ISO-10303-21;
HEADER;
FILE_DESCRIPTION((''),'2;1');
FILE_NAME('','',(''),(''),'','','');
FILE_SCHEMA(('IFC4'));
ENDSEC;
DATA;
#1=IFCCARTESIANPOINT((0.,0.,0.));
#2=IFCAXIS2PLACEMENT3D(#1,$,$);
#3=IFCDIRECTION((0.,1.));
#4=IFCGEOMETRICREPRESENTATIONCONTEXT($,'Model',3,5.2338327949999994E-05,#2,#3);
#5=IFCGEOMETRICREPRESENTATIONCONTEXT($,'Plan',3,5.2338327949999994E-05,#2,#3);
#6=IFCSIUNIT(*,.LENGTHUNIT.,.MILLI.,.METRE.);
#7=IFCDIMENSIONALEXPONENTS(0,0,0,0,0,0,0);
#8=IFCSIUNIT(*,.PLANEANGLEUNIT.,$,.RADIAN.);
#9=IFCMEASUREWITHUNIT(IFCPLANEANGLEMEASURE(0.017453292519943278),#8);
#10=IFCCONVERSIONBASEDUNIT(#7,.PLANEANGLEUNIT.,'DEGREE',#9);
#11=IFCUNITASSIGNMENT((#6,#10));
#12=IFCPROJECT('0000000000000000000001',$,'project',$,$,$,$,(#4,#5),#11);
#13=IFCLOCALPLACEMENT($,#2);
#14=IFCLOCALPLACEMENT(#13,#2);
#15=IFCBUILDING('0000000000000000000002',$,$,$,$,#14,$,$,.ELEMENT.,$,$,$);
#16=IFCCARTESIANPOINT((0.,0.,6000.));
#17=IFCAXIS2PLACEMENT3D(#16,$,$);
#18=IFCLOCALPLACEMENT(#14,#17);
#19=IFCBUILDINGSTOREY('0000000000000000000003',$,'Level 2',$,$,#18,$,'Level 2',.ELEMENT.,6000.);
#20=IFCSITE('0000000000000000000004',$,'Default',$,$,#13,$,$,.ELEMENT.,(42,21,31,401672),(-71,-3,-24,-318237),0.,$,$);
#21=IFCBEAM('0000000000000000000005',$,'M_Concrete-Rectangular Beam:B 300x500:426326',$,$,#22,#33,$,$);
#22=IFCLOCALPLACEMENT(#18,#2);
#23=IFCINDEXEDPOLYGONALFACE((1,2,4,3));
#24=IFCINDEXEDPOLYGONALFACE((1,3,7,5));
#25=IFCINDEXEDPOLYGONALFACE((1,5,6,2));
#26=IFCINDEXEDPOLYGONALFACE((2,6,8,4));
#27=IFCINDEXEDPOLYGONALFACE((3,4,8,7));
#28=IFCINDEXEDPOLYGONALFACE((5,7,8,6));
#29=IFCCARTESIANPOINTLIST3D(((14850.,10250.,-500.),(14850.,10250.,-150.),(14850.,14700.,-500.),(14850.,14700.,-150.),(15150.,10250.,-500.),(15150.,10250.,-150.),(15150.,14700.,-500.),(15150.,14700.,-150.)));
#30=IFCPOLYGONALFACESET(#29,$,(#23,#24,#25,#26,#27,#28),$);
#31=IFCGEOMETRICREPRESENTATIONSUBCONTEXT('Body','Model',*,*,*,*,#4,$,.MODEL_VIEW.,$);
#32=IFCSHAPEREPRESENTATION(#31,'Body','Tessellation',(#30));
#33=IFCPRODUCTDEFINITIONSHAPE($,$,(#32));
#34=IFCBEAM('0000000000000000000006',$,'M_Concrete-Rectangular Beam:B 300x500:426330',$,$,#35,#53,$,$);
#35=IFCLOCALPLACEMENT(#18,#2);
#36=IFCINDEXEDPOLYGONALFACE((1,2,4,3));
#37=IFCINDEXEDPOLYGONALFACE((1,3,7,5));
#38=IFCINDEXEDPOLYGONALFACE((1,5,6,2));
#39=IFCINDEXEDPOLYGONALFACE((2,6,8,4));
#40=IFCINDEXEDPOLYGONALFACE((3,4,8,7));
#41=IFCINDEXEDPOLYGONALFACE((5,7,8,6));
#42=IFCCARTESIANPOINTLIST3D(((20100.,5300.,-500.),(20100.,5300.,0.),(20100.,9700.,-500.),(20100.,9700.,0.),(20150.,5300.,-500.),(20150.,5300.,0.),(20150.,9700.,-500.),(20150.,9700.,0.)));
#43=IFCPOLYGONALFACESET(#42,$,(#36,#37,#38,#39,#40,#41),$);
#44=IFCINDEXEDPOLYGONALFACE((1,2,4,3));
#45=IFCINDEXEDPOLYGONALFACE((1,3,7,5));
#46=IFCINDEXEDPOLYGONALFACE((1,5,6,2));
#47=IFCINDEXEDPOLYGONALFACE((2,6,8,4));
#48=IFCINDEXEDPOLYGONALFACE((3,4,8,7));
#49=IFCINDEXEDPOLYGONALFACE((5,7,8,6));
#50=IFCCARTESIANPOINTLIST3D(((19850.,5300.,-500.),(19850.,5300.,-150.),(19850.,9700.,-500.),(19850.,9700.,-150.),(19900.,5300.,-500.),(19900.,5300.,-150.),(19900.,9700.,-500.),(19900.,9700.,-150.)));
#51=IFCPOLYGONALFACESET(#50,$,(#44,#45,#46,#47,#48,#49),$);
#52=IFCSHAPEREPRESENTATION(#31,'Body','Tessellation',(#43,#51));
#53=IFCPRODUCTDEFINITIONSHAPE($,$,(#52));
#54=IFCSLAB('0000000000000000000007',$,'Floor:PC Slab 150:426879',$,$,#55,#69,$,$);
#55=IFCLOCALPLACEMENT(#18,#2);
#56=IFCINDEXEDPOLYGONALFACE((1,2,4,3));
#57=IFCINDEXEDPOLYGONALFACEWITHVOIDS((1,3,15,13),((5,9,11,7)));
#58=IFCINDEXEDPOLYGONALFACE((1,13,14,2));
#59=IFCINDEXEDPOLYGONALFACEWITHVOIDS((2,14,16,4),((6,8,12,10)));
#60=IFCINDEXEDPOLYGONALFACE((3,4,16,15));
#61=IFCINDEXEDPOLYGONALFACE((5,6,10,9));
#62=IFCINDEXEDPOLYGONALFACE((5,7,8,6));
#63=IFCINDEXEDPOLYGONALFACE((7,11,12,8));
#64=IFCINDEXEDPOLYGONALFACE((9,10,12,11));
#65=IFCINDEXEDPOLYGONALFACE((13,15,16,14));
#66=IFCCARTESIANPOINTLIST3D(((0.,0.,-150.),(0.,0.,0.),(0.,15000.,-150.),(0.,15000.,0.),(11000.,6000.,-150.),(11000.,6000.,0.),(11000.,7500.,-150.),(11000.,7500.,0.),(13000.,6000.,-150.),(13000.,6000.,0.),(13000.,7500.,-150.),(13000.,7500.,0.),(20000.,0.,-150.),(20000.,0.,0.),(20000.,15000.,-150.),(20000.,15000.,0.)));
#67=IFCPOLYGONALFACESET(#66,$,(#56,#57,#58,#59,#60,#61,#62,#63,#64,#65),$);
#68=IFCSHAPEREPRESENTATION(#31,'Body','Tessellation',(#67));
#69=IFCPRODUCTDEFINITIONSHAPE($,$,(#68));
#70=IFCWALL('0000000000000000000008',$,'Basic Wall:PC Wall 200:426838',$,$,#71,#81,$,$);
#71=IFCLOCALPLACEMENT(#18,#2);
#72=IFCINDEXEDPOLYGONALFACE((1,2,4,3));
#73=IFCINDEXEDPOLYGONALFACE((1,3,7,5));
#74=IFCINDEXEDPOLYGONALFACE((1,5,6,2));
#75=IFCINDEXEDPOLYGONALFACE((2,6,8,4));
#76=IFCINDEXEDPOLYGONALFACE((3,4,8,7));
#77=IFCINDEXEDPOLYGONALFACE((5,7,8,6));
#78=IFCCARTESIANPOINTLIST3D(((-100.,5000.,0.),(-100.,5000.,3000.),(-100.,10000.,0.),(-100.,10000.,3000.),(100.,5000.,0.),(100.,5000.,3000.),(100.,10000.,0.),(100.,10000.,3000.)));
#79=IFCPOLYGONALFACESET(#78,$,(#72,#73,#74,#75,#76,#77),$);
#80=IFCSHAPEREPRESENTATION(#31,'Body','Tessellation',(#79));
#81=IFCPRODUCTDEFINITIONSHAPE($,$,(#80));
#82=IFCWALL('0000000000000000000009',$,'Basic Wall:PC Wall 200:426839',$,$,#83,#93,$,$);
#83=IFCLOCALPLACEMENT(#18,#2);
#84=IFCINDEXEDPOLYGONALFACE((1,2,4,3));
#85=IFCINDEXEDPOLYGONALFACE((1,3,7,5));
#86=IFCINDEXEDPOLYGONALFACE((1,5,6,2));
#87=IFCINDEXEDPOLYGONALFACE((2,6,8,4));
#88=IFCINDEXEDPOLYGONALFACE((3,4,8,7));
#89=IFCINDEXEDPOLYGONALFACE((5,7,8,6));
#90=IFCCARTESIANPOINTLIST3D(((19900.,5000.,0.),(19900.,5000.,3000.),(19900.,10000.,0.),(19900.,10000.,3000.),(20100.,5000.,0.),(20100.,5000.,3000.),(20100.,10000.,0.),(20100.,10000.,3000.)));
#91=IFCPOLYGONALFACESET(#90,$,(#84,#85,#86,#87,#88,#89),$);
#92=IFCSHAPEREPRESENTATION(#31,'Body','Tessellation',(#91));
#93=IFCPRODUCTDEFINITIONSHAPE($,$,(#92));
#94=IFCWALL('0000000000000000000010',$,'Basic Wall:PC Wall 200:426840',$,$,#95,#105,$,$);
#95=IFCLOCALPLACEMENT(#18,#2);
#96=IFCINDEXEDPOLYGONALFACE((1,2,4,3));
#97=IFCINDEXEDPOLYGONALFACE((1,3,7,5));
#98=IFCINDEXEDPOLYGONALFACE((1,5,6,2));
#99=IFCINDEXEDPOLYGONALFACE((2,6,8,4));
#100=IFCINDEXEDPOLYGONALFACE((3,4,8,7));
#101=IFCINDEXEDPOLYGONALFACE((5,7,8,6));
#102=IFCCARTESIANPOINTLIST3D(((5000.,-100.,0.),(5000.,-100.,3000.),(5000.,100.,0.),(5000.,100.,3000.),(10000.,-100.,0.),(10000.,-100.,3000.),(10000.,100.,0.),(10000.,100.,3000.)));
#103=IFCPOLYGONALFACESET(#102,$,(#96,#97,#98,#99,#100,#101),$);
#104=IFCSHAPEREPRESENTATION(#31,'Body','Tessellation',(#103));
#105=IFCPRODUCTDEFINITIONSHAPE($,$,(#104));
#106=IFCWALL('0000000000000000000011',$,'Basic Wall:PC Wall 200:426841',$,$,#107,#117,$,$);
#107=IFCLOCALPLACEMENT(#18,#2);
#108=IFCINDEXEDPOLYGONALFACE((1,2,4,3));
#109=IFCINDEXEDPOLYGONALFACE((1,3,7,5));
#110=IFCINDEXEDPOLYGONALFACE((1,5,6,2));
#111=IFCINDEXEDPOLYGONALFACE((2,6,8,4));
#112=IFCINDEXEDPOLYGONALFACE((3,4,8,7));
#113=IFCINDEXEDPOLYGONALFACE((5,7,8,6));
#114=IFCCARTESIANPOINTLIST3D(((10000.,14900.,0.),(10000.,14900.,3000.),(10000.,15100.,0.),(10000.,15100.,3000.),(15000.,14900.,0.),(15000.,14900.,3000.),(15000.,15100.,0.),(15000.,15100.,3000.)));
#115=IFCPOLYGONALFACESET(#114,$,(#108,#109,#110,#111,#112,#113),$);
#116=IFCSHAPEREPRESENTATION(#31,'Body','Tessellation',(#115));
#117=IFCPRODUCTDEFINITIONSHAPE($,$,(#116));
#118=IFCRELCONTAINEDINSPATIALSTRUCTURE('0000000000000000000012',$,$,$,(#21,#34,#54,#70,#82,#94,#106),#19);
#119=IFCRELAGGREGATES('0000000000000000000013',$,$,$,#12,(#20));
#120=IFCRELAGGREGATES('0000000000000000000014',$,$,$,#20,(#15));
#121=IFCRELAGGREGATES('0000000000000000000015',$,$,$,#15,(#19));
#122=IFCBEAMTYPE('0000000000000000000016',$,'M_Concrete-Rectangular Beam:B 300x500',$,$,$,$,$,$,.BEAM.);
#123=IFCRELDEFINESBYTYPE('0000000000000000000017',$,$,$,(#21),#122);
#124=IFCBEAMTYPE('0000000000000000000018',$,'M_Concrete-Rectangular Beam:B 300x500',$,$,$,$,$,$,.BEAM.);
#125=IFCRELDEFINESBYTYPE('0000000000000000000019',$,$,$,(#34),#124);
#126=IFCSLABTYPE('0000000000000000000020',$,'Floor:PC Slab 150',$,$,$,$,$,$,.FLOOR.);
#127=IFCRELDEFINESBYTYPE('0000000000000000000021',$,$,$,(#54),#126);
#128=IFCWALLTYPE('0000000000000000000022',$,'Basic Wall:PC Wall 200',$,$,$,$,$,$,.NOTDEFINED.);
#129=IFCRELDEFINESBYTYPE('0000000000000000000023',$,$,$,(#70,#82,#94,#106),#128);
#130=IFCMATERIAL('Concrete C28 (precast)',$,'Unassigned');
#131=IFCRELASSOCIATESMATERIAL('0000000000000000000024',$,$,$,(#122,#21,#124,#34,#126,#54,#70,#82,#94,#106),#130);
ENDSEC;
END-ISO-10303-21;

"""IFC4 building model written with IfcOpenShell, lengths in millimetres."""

from ifc_helpers import new_model, entity, si_unit, converted_unit, direction, frame, origin, place, context, subcontext, project, spatial, indexed_curve, outline, extrude, source, transform, mapped, material, type_object, type_shapes, element, save


model = new_model("IFC4")

# Units and contexts
model_context = context("Model", 3, precision=5.2338327949999994e-05, world=origin(), true_north=direction((0.0, 1.0)))
plan_context = context("Plan", 3, precision=5.2338327949999994e-05, world=origin(), true_north=direction((0.0, 1.0)))
body_context = subcontext(model_context, "Body", "Model", "MODEL_VIEW")
ifc_project = project(units=[si_unit("LENGTHUNIT", "METRE", prefix="MILLI"), converted_unit("PLANEANGLEUNIT", "DEGREE", entity("IfcPlaneAngleMeasure", 0.017453292519943278), si_unit("PLANEANGLEUNIT", "RADIAN"), dimensions=[0, 0, 0, 0, 0, 0, 0])], contexts=[model_context, plan_context])

# Site, building, storey
site_placement = place(None, origin())
site = spatial("IfcSite", under=ifc_project, at=site_placement, Name="Default", CompositionType="ELEMENT", RefLatitude=(42, 21, 31, 401672), RefLongitude=(-71, -3, -24, -318237), RefElevation=0.0)
building_placement = place(site_placement, origin())
building = spatial("IfcBuilding", under=site, at=building_placement, CompositionType="ELEMENT")
storey_placement = place(building_placement, frame((0.0, 0.0, 6000.0)))
storey = spatial("IfcBuildingStorey", under=building, at=storey_placement, Name="Level 2", LongName="Level 2", CompositionType="ELEMENT", Elevation=6000.0)

# Beams
ifc_material = material(Name="Concrete C28 (precast)", Category="Unassigned")
beam_type_1 = type_object("IfcBeamType", Name="M_Concrete-Rectangular Beam:B 300x500", PredefinedType="BEAM", material=ifc_material)
shared_shape_1 = source(origin(), body_context, "Body", "SweptSolid", [
    extrude(outline(indexed_curve([(-150.0, -175.0), (150.0, -175.0), (150.0, 175.0), (-150.0, 175.0), (-150.0, -175.0)], self_intersect=False)), frame((15000.0, 10250.0, 5675.0), z_axis=(0.0, 1.0, 0.0), x_axis=(-1.0, 0.0, 0.0)), (0.0, 0.0, 1.0), 4450.0),
])
type_shapes(beam_type_1, [shared_shape_1])
beam_1_placement = place(storey_placement, frame((0.0, 0.0, -6000.0)))
element("IfcBeam", 1, at=beam_1_placement, inside=storey, type_object=beam_type_1, material=ifc_material, Name="M_Concrete-Rectangular Beam:B 300x500:426326", context=body_context, shape_type="MappedRepresentation", body=[
    mapped(shared_shape_1, transform((0.0, 0.0, 0.0), scale=1.0)),
])
beam_type_2 = type_object("IfcBeamType", Name="M_Concrete-Rectangular Beam:B 300x500", PredefinedType="BEAM", material=ifc_material)
shared_shape_2 = source(origin(), body_context, "Body", "SweptSolid", [
    extrude(outline(indexed_curve([(-25.0, -250.0), (25.0, -250.0), (25.0, 250.0), (-25.0, 250.0), (-25.0, -250.0)], self_intersect=False)), frame((20125.0, 5300.0, 5750.0), z_axis=(0.0, 1.0, 0.0), x_axis=(-1.0, 0.0, 0.0)), (0.0, 0.0, 1.0), 4400.0),
    extrude(outline(indexed_curve([(-25.0, -175.0), (25.0, -175.0), (25.0, 175.0), (-25.0, 175.0), (-25.0, -175.0)], self_intersect=False)), frame((19875.0, 5300.0, 5675.0), z_axis=(0.0, 1.0, 0.0), x_axis=(-1.0, 0.0, 0.0)), (0.0, 0.0, 1.0), 4400.0),
])
type_shapes(beam_type_2, [shared_shape_2])
beam_2_placement = place(storey_placement, frame((0.0, 0.0, -6000.0)))
element("IfcBeam", 2, at=beam_2_placement, inside=storey, type_object=beam_type_2, material=ifc_material, Name="M_Concrete-Rectangular Beam:B 300x500:426330", context=body_context, shape_type="MappedRepresentation", body=[
    mapped(shared_shape_2, transform((0.0, 0.0, 0.0), scale=1.0)),
])

# Slab, opening
slab_type = type_object("IfcSlabType", Name="Floor:PC Slab 150", PredefinedType="FLOOR", material=ifc_material)
slab_placement = place(storey_placement, origin())
slab = element("IfcSlab", 3, at=slab_placement, inside=storey, type_object=slab_type, material=ifc_material, Name="Floor:PC Slab 150:426879", context=body_context, shape_type="SweptSolid", body=[
    extrude(outline(indexed_curve([(-7500.0, -10000.0), (7500.0, -10000.0), (7500.0, 10000.0), (-7500.0, 10000.0), (-7500.0, -10000.0)], self_intersect=False), holes=[indexed_curve([(-1500.0, -3000.0), (-1500.0, -1000.0), (0.0, -1000.0), (0.0, -3000.0), (-1500.0, -3000.0)], self_intersect=False)]), frame((10000.0, 7500.0, -150.0), z_axis=(0.0, 0.0, 1.0), x_axis=(0.0, 1.0, 0.0)), (0.0, 0.0, 1.0), 150.0),
])
opening_placement = place(slab_placement, origin())
element("IfcOpeningElement", 4, at=opening_placement, cuts=slab, PredefinedType="OPENING", context=body_context, shape_type="SweptSolid", body=[
    extrude(outline(indexed_curve([(13000.0, 6000.0), (13000.0, 7500.0), (11000.0, 7500.0), (11000.0, 6000.0), (13000.0, 6000.0)], self_intersect=False)), frame((0.0, 0.0, -6000.0)), (0.0, 0.0, 1.0), 20000.0),
])

# Walls
wall_type = type_object("IfcWallType", Name="Basic Wall:PC Wall 200", PredefinedType="NOTDEFINED")
wall_1_placement = place(storey_placement, frame((0.0, 5000.0, 0.0), z_axis=(0.0, 0.0, 1.0), x_axis=(0.0, 1.0, 0.0)))
element("IfcWall", 5, at=wall_1_placement, inside=storey, type_object=wall_type, material=ifc_material, Name="Basic Wall:PC Wall 200:426838", context=body_context, shape_type="SweptSolid", body=[
    extrude(outline(indexed_curve([(5000.0, 100.0), (0.0, 100.0), (0.0, -100.0), (5000.0, -100.0), (5000.0, 100.0)], self_intersect=False)), origin(), (0.0, 0.0, 1.0), 3000.0),
])
wall_2_placement = place(storey_placement, frame((20000.0, 5000.0, 0.0), z_axis=(0.0, 0.0, 1.0), x_axis=(0.0, 1.0, 0.0)))
element("IfcWall", 6, at=wall_2_placement, inside=storey, type_object=wall_type, material=ifc_material, Name="Basic Wall:PC Wall 200:426839", context=body_context, shape_type="SweptSolid", body=[
    extrude(outline(indexed_curve([(5000.0, 100.0), (0.0, 100.0), (0.0, -100.0), (5000.0, -100.0), (5000.0, 100.0)], self_intersect=False)), origin(), (0.0, 0.0, 1.0), 3000.0),
])
wall_3_placement = place(storey_placement, frame((5000.0, 0.0, 0.0)))
element("IfcWall", 7, at=wall_3_placement, inside=storey, type_object=wall_type, material=ifc_material, Name="Basic Wall:PC Wall 200:426840", context=body_context, shape_type="SweptSolid", body=[
    extrude(outline(indexed_curve([(5000.0, 100.0), (0.0, 100.0), (0.0, -100.0), (5000.0, -100.0), (5000.0, 100.0)], self_intersect=False)), origin(), (0.0, 0.0, 1.0), 3000.0),
])
wall_4_placement = place(storey_placement, frame((10000.0, 15000.0, 0.0)))
element("IfcWall", 8, at=wall_4_placement, inside=storey, type_object=wall_type, material=ifc_material, Name="Basic Wall:PC Wall 200:426841", context=body_context, shape_type="SweptSolid", body=[
    extrude(outline(indexed_curve([(5000.0, 100.0), (0.0, 100.0), (0.0, -100.0), (5000.0, -100.0), (5000.0, 100.0)], self_intersect=False)), origin(), (0.0, 0.0, 1.0), 3000.0),
])

save(model, "model.ifc")
